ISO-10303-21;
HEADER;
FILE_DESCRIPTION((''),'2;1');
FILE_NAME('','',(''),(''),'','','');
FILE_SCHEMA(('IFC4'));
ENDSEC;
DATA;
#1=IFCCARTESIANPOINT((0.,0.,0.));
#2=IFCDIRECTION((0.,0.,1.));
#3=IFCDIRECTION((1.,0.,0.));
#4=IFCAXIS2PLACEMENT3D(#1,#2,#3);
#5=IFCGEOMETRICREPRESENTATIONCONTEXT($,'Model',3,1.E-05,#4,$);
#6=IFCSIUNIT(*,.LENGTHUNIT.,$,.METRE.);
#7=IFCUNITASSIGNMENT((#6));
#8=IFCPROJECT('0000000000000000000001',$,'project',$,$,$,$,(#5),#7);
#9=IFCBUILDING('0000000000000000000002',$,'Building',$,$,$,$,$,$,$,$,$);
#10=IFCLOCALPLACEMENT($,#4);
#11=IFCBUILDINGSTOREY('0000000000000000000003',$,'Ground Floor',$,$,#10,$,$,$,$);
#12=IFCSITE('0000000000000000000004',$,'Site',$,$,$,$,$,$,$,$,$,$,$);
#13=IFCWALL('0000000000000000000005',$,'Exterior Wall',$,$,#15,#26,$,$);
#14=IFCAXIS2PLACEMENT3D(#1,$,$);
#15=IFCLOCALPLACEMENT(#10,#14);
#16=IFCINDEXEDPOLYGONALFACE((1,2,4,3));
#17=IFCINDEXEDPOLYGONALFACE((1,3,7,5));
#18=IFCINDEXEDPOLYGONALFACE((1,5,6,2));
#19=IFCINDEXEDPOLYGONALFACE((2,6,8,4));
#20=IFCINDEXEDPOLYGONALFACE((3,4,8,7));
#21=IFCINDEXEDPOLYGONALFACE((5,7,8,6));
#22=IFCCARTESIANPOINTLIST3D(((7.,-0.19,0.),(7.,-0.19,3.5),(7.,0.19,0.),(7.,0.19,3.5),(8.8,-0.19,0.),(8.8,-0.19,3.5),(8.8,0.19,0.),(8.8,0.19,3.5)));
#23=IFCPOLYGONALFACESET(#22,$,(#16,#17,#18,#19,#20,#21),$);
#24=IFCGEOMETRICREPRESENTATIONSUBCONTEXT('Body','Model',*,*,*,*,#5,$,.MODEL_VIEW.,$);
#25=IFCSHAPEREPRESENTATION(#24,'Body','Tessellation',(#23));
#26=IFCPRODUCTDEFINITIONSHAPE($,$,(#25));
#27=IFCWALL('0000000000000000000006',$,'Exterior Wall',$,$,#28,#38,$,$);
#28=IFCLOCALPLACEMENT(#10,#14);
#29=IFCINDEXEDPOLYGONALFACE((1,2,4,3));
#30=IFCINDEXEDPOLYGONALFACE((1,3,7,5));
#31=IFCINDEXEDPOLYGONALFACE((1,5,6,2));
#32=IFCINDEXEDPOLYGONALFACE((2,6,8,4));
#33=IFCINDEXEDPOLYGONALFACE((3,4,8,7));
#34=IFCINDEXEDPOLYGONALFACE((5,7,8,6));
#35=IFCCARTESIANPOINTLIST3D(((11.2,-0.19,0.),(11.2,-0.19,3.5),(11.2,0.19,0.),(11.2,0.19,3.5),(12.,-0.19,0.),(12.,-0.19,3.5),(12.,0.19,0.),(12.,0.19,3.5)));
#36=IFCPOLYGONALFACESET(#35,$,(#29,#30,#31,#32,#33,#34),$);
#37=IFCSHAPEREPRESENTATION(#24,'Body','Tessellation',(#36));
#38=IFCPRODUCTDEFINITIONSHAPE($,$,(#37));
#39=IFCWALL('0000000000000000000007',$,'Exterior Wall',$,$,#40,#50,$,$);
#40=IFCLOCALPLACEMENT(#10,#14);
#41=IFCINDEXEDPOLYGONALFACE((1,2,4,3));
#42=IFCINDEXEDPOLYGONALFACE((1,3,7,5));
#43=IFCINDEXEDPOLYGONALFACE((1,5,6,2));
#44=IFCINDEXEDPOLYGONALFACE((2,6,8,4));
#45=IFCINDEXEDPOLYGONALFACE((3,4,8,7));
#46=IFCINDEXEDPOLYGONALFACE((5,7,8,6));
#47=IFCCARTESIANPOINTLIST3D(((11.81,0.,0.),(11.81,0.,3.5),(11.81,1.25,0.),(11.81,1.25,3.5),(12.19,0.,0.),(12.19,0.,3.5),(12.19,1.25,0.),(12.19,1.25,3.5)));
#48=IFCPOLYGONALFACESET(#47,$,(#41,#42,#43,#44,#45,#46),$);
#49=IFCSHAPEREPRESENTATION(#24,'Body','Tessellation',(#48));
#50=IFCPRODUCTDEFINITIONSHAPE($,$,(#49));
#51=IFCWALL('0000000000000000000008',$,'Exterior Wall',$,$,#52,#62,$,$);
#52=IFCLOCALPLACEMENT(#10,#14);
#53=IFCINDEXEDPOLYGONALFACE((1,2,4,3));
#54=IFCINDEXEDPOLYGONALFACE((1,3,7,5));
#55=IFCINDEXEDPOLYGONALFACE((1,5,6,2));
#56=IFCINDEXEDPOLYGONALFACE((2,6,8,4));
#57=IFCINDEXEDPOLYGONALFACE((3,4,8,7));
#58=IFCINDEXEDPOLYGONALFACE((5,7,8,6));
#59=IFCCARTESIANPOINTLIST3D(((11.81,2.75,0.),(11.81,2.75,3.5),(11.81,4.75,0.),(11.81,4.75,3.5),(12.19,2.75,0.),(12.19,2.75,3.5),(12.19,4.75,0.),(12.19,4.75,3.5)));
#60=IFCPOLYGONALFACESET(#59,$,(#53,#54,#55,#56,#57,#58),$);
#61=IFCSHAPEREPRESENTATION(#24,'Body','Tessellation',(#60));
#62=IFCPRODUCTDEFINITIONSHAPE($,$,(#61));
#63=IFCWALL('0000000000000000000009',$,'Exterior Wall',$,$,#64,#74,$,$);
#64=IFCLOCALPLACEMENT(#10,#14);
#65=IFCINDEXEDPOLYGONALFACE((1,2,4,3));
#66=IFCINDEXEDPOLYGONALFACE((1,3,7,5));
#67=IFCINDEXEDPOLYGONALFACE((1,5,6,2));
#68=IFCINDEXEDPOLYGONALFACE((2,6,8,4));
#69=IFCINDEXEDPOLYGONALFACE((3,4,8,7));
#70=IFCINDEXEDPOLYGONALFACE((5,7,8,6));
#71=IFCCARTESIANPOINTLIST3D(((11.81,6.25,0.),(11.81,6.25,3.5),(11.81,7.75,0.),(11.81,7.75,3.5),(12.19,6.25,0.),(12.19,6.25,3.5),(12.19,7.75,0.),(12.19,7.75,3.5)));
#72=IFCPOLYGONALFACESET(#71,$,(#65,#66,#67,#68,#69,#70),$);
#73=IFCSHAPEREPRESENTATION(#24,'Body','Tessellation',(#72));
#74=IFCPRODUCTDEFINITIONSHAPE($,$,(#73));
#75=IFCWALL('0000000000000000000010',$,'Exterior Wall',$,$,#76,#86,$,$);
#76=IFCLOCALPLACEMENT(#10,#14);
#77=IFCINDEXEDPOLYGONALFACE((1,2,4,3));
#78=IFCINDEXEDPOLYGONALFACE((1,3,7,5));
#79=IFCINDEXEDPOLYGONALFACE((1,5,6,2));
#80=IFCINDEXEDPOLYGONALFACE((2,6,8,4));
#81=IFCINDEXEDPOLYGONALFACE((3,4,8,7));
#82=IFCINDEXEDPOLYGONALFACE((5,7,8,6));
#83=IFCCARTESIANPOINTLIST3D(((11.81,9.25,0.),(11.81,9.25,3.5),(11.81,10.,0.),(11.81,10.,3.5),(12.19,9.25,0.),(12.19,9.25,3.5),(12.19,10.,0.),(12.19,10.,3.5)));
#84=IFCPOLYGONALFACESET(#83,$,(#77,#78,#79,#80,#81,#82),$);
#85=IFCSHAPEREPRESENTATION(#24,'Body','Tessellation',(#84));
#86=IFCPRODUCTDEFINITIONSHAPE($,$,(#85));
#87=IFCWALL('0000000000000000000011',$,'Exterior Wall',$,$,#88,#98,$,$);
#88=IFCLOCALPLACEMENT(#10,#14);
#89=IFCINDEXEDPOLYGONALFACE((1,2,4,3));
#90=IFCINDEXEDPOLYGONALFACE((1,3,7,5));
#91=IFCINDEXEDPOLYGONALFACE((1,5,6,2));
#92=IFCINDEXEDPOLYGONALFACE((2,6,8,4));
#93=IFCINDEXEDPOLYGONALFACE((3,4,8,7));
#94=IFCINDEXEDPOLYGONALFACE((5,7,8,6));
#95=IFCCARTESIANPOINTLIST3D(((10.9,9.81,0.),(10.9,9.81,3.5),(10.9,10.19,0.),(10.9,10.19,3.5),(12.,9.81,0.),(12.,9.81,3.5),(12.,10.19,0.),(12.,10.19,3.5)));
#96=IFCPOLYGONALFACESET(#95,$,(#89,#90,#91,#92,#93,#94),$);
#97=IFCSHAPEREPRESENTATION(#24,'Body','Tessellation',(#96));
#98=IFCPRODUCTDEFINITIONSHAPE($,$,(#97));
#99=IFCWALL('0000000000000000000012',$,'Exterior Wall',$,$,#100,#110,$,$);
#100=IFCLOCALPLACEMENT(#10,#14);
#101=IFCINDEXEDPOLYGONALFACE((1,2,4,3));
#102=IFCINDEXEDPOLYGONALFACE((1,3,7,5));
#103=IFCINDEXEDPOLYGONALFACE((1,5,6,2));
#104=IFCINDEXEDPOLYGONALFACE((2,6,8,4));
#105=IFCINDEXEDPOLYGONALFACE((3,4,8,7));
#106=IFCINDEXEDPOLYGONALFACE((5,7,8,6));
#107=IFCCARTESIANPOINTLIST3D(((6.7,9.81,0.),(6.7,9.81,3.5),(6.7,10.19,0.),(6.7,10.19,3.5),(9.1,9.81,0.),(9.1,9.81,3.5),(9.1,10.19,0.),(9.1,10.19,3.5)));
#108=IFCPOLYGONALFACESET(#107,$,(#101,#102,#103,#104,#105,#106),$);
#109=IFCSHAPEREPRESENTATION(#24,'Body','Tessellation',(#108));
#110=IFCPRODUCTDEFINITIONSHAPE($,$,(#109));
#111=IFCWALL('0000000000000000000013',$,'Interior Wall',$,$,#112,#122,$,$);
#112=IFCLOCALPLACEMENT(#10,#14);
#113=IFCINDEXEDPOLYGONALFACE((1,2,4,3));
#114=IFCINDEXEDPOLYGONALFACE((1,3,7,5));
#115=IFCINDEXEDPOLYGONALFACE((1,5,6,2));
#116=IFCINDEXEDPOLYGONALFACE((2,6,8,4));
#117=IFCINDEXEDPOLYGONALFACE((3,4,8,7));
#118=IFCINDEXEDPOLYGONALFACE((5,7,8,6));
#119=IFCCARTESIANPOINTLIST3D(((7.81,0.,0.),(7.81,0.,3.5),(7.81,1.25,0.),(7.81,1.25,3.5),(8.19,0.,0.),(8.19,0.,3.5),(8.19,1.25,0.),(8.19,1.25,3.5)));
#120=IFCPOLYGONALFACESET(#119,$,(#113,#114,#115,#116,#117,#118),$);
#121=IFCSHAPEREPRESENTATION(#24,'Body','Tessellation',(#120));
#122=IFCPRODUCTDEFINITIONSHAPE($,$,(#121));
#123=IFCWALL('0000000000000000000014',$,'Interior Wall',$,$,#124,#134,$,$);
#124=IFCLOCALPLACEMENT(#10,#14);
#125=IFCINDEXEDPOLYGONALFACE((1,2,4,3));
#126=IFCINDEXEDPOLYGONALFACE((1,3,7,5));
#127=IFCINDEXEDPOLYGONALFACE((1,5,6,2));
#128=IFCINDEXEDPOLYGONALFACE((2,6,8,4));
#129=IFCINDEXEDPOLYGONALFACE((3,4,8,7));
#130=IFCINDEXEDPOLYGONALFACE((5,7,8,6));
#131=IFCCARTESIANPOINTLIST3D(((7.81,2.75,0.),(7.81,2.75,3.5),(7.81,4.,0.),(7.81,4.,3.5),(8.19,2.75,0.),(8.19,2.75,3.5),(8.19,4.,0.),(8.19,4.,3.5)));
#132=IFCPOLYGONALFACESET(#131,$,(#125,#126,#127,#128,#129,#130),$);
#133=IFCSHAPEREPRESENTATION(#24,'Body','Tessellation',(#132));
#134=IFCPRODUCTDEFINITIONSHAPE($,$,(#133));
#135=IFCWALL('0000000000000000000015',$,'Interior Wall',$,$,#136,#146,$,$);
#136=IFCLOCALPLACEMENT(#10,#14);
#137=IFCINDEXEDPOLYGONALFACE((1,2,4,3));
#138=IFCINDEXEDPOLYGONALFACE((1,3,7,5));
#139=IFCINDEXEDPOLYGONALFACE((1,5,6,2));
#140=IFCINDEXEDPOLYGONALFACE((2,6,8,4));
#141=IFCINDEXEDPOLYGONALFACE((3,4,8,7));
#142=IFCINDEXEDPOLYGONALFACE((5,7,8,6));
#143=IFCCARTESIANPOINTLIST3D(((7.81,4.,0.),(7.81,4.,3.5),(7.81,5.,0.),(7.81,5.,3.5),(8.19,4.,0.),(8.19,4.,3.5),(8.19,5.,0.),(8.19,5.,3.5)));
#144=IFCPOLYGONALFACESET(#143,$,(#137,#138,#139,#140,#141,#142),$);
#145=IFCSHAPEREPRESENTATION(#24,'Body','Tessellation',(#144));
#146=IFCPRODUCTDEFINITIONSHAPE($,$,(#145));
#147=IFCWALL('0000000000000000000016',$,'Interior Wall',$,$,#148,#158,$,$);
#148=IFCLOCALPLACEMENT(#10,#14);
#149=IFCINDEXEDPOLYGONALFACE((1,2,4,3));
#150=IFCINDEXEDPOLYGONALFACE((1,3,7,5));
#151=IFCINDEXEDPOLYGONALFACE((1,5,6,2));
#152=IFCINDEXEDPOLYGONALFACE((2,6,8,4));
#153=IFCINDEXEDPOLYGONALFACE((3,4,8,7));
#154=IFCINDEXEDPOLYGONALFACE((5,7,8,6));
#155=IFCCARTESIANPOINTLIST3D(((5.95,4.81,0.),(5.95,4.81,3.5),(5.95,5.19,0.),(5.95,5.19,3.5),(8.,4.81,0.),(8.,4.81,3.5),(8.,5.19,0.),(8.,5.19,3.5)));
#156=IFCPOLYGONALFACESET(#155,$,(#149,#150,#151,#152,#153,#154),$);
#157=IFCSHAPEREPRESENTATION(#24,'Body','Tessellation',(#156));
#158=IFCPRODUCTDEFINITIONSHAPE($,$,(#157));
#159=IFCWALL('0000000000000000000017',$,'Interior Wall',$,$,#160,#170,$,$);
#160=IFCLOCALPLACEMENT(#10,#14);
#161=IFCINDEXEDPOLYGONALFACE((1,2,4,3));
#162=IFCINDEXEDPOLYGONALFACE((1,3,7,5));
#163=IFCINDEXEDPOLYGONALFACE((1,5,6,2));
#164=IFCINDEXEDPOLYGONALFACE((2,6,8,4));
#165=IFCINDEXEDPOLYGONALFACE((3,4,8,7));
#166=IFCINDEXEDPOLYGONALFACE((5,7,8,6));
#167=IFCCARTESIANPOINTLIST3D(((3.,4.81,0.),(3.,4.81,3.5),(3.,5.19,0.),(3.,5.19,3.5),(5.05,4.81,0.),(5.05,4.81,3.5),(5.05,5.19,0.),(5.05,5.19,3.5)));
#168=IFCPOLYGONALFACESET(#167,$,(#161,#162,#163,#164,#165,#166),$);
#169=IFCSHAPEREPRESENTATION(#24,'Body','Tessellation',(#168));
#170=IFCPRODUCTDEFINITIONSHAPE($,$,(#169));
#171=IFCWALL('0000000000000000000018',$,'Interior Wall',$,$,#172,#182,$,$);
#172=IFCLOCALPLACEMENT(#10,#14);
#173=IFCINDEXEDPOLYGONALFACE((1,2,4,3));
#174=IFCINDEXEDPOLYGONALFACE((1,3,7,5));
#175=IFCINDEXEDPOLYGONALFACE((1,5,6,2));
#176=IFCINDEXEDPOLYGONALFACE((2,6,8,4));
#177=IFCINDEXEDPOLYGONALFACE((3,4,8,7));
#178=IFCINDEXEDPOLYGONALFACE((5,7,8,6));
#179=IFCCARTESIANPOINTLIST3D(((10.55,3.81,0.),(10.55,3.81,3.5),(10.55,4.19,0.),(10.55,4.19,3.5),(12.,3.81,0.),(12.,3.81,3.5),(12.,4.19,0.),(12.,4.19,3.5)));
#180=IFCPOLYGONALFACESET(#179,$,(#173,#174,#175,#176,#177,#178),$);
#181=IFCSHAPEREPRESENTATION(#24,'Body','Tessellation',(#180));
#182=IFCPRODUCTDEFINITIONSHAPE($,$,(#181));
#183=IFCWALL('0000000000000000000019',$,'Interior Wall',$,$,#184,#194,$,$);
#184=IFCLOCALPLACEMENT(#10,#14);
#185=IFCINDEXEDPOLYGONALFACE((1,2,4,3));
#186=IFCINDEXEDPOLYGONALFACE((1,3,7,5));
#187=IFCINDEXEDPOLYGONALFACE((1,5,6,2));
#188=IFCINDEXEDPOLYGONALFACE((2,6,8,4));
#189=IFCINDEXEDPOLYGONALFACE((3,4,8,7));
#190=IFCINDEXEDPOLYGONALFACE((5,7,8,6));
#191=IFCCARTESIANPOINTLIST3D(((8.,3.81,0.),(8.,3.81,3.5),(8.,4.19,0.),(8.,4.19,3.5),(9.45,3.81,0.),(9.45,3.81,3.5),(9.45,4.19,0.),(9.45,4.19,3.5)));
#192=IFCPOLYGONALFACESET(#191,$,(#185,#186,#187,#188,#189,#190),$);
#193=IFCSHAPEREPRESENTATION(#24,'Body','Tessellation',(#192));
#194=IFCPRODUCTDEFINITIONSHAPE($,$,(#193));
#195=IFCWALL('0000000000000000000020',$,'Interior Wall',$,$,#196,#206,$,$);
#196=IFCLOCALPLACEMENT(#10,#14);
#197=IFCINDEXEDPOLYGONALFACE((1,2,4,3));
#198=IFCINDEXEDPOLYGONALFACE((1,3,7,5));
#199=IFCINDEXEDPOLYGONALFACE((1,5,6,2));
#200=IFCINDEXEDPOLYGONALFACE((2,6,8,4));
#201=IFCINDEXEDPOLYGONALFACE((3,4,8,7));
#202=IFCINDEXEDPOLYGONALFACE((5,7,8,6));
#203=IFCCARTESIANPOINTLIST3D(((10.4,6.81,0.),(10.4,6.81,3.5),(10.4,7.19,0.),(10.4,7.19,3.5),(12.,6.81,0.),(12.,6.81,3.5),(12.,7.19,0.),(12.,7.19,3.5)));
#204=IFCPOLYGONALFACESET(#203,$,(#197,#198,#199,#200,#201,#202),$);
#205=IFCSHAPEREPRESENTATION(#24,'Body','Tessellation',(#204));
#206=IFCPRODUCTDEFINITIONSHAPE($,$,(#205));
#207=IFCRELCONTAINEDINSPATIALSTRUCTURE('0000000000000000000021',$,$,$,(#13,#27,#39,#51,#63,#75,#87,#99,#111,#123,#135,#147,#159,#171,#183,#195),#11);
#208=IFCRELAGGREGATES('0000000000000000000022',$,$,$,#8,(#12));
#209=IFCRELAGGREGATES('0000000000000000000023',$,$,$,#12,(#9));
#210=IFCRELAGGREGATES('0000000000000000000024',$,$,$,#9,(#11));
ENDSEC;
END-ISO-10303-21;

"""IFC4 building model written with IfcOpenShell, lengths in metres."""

from ifc_helpers import new_model, si_unit, frame, origin_with_axes, place, context, subcontext, project, spatial, indexed_curve, outline, extrude, element, save


model = new_model("IFC4")

# Units and contexts
model_context = context("Model", 3, precision=1e-05, world=origin_with_axes())
body_context = subcontext(model_context, "Body", "Model", "MODEL_VIEW")
ifc_project = project(units=[si_unit("LENGTHUNIT", "METRE")], contexts=[model_context])

# Site, building, storey
site = spatial("IfcSite", under=ifc_project, Name="Site")
building = spatial("IfcBuilding", under=site, Name="Building")
storey_placement = place(None, origin_with_axes())
storey = spatial("IfcBuildingStorey", under=building, at=storey_placement, Name="Ground Floor")

# Walls
wall_1_placement = place(storey_placement, frame((7.0, 0.0, 0.0), z_axis=(0.0, 0.0, 1.0), x_axis=(1.0, 0.0, 0.0)))
element("IfcWall", 1, at=wall_1_placement, inside=storey, Name="Exterior Wall", context=body_context, shape_type="SweptSolid", body=[
    extrude(outline(indexed_curve([(0.0, 0.0), (0.0, 0.38), (1.8, 0.38), (1.8, 0.0), (0.0, 0.0)], self_intersect=False)), frame((0.0, -0.19, 0.0), z_axis=(0.0, 0.0, 1.0), x_axis=(1.0, 0.0, 0.0)), (0.0, 0.0, 1.0), 3.5),
])
wall_2_placement = place(storey_placement, frame((11.2, 0.0, 0.0), z_axis=(0.0, 0.0, 1.0), x_axis=(1.0, 0.0, 0.0)))
element("IfcWall", 2, at=wall_2_placement, inside=storey, Name="Exterior Wall", context=body_context, shape_type="SweptSolid", body=[
    extrude(outline(indexed_curve([(0.0, 0.0), (0.0, 0.38), (0.8, 0.38), (0.8, 0.0), (0.0, 0.0)], self_intersect=False)), frame((0.0, -0.19, 0.0), z_axis=(0.0, 0.0, 1.0), x_axis=(1.0, 0.0, 0.0)), (0.0, 0.0, 1.0), 3.5),
])
wall_3_placement = place(storey_placement, frame((12.0, 0.0, 0.0), z_axis=(0.0, 0.0, 1.0), x_axis=(0.0, 1.0, 0.0)))
element("IfcWall", 3, at=wall_3_placement, inside=storey, Name="Exterior Wall", context=body_context, shape_type="SweptSolid", body=[
    extrude(outline(indexed_curve([(0.0, 0.0), (0.0, 0.38), (1.25, 0.38), (1.25, 0.0), (0.0, 0.0)], self_intersect=False)), frame((0.0, -0.19, 0.0), z_axis=(0.0, 0.0, 1.0), x_axis=(1.0, 0.0, 0.0)), (0.0, 0.0, 1.0), 3.5),
])
wall_4_placement = place(storey_placement, frame((12.0, 2.75, 0.0), z_axis=(0.0, 0.0, 1.0), x_axis=(0.0, 1.0, 0.0)))
element("IfcWall", 4, at=wall_4_placement, inside=storey, Name="Exterior Wall", context=body_context, shape_type="SweptSolid", body=[
    extrude(outline(indexed_curve([(0.0, 0.0), (0.0, 0.38), (2.0, 0.38), (2.0, 0.0), (0.0, 0.0)], self_intersect=False)), frame((0.0, -0.19, 0.0), z_axis=(0.0, 0.0, 1.0), x_axis=(1.0, 0.0, 0.0)), (0.0, 0.0, 1.0), 3.5),
])
wall_5_placement = place(storey_placement, frame((12.0, 6.25, 0.0), z_axis=(0.0, 0.0, 1.0), x_axis=(0.0, 1.0, 0.0)))
element("IfcWall", 5, at=wall_5_placement, inside=storey, Name="Exterior Wall", context=body_context, shape_type="SweptSolid", body=[
    extrude(outline(indexed_curve([(0.0, 0.0), (0.0, 0.38), (1.5, 0.38), (1.5, 0.0), (0.0, 0.0)], self_intersect=False)), frame((0.0, -0.19, 0.0), z_axis=(0.0, 0.0, 1.0), x_axis=(1.0, 0.0, 0.0)), (0.0, 0.0, 1.0), 3.5),
])
wall_6_placement = place(storey_placement, frame((12.0, 9.25, 0.0), z_axis=(0.0, 0.0, 1.0), x_axis=(0.0, 1.0, 0.0)))
element("IfcWall", 6, at=wall_6_placement, inside=storey, Name="Exterior Wall", context=body_context, shape_type="SweptSolid", body=[
    extrude(outline(indexed_curve([(0.0, 0.0), (0.0, 0.38), (0.75, 0.38), (0.75, 0.0), (0.0, 0.0)], self_intersect=False)), frame((0.0, -0.19, 0.0), z_axis=(0.0, 0.0, 1.0), x_axis=(1.0, 0.0, 0.0)), (0.0, 0.0, 1.0), 3.5),
])
wall_7_placement = place(storey_placement, frame((12.0, 10.0, 0.0), z_axis=(0.0, 0.0, 1.0), x_axis=(-1.0, 0.0, 0.0)))
element("IfcWall", 7, at=wall_7_placement, inside=storey, Name="Exterior Wall", context=body_context, shape_type="SweptSolid", body=[
    extrude(outline(indexed_curve([(0.0, 0.0), (0.0, 0.38), (1.1, 0.38), (1.1, 0.0), (0.0, 0.0)], self_intersect=False)), frame((0.0, -0.19, 0.0), z_axis=(0.0, 0.0, 1.0), x_axis=(1.0, 0.0, 0.0)), (0.0, 0.0, 1.0), 3.5),
])
wall_8_placement = place(storey_placement, frame((9.1, 10.0, 0.0), z_axis=(0.0, 0.0, 1.0), x_axis=(-1.0, 0.0, 0.0)))
element("IfcWall", 8, at=wall_8_placement, inside=storey, Name="Exterior Wall", context=body_context, shape_type="SweptSolid", body=[
    extrude(outline(indexed_curve([(0.0, 0.0), (0.0, 0.38), (2.4, 0.38), (2.4, 0.0), (0.0, 0.0)], self_intersect=False)), frame((0.0, -0.19, 0.0), z_axis=(0.0, 0.0, 1.0), x_axis=(1.0, 0.0, 0.0)), (0.0, 0.0, 1.0), 3.5),
])
for number, where, z_axis, x_axis, name in (
    (9, (8.0, 0.0, 0.0), (0.0, 0.0, 1.0), (0.0, 1.0, 0.0), "Interior Wall"),
    (10, (8.0, 2.75, 0.0), (0.0, 0.0, 1.0), (0.0, 1.0, 0.0), "Interior Wall"),
):
    element("IfcWall", number, at=place(storey_placement, frame(where, z_axis=z_axis, x_axis=x_axis)), inside=storey, Name=name, context=body_context, shape_type="SweptSolid", body=[
        extrude(outline(indexed_curve([(0.0, 0.0), (0.0, 0.38), (1.25, 0.38), (1.25, 0.0), (0.0, 0.0)], self_intersect=False)), frame((0.0, -0.19, 0.0), z_axis=(0.0, 0.0, 1.0), x_axis=(1.0, 0.0, 0.0)), (0.0, 0.0, 1.0), 3.5),
    ])
wall_9_placement = place(storey_placement, frame((8.0, 4.0, 0.0), z_axis=(0.0, 0.0, 1.0), x_axis=(0.0, 1.0, 0.0)))
element("IfcWall", 11, at=wall_9_placement, inside=storey, Name="Interior Wall", context=body_context, shape_type="SweptSolid", body=[
    extrude(outline(indexed_curve([(0.0, 0.0), (0.0, 0.38), (1.0, 0.38), (1.0, 0.0), (0.0, 0.0)], self_intersect=False)), frame((0.0, -0.19, 0.0), z_axis=(0.0, 0.0, 1.0), x_axis=(1.0, 0.0, 0.0)), (0.0, 0.0, 1.0), 3.5),
])
for number, where, z_axis, x_axis, name in (
    (12, (8.0, 5.0, 0.0), (0.0, 0.0, 1.0), (-1.0, 0.0, 0.0), "Interior Wall"),
    (13, (5.05, 5.0, 0.0), (0.0, 0.0, 1.0), (-1.0, 0.0, 0.0), "Interior Wall"),
):
    element("IfcWall", number, at=place(storey_placement, frame(where, z_axis=z_axis, x_axis=x_axis)), inside=storey, Name=name, context=body_context, shape_type="SweptSolid", body=[
        extrude(outline(indexed_curve([(0.0, 0.0), (0.0, 0.38), (2.05, 0.38), (2.05, 0.0), (0.0, 0.0)], self_intersect=False)), frame((0.0, -0.19, 0.0), z_axis=(0.0, 0.0, 1.0), x_axis=(1.0, 0.0, 0.0)), (0.0, 0.0, 1.0), 3.5),
    ])
for number, where, z_axis, x_axis, name in (
    (14, (12.0, 4.0, 0.0), (0.0, 0.0, 1.0), (-1.0, 0.0, 0.0), "Interior Wall"),
    (15, (9.45, 4.0, 0.0), (0.0, 0.0, 1.0), (-1.0, 0.0, 0.0), "Interior Wall"),
):
    element("IfcWall", number, at=place(storey_placement, frame(where, z_axis=z_axis, x_axis=x_axis)), inside=storey, Name=name, context=body_context, shape_type="SweptSolid", body=[
        extrude(outline(indexed_curve([(0.0, 0.0), (0.0, 0.38), (1.45, 0.38), (1.45, 0.0), (0.0, 0.0)], self_intersect=False)), frame((0.0, -0.19, 0.0), z_axis=(0.0, 0.0, 1.0), x_axis=(1.0, 0.0, 0.0)), (0.0, 0.0, 1.0), 3.5),
    ])
for number, where, z_axis, x_axis, name in (
    (16, (12.0, 7.0, 0.0), (0.0, 0.0, 1.0), (-1.0, 0.0, 0.0), "Interior Wall"),
):
    element("IfcWall", number, at=place(storey_placement, frame(where, z_axis=z_axis, x_axis=x_axis)), inside=storey, Name=name, context=body_context, shape_type="SweptSolid", body=[
        extrude(outline(indexed_curve([(0.0, 0.0), (0.0, 0.38), (1.6, 0.38), (1.6, 0.0), (0.0, 0.0)], self_intersect=False)), frame((0.0, -0.19, 0.0), z_axis=(0.0, 0.0, 1.0), x_axis=(1.0, 0.0, 0.0)), (0.0, 0.0, 1.0), 3.5),
    ])

save(model, "model.ifc")
